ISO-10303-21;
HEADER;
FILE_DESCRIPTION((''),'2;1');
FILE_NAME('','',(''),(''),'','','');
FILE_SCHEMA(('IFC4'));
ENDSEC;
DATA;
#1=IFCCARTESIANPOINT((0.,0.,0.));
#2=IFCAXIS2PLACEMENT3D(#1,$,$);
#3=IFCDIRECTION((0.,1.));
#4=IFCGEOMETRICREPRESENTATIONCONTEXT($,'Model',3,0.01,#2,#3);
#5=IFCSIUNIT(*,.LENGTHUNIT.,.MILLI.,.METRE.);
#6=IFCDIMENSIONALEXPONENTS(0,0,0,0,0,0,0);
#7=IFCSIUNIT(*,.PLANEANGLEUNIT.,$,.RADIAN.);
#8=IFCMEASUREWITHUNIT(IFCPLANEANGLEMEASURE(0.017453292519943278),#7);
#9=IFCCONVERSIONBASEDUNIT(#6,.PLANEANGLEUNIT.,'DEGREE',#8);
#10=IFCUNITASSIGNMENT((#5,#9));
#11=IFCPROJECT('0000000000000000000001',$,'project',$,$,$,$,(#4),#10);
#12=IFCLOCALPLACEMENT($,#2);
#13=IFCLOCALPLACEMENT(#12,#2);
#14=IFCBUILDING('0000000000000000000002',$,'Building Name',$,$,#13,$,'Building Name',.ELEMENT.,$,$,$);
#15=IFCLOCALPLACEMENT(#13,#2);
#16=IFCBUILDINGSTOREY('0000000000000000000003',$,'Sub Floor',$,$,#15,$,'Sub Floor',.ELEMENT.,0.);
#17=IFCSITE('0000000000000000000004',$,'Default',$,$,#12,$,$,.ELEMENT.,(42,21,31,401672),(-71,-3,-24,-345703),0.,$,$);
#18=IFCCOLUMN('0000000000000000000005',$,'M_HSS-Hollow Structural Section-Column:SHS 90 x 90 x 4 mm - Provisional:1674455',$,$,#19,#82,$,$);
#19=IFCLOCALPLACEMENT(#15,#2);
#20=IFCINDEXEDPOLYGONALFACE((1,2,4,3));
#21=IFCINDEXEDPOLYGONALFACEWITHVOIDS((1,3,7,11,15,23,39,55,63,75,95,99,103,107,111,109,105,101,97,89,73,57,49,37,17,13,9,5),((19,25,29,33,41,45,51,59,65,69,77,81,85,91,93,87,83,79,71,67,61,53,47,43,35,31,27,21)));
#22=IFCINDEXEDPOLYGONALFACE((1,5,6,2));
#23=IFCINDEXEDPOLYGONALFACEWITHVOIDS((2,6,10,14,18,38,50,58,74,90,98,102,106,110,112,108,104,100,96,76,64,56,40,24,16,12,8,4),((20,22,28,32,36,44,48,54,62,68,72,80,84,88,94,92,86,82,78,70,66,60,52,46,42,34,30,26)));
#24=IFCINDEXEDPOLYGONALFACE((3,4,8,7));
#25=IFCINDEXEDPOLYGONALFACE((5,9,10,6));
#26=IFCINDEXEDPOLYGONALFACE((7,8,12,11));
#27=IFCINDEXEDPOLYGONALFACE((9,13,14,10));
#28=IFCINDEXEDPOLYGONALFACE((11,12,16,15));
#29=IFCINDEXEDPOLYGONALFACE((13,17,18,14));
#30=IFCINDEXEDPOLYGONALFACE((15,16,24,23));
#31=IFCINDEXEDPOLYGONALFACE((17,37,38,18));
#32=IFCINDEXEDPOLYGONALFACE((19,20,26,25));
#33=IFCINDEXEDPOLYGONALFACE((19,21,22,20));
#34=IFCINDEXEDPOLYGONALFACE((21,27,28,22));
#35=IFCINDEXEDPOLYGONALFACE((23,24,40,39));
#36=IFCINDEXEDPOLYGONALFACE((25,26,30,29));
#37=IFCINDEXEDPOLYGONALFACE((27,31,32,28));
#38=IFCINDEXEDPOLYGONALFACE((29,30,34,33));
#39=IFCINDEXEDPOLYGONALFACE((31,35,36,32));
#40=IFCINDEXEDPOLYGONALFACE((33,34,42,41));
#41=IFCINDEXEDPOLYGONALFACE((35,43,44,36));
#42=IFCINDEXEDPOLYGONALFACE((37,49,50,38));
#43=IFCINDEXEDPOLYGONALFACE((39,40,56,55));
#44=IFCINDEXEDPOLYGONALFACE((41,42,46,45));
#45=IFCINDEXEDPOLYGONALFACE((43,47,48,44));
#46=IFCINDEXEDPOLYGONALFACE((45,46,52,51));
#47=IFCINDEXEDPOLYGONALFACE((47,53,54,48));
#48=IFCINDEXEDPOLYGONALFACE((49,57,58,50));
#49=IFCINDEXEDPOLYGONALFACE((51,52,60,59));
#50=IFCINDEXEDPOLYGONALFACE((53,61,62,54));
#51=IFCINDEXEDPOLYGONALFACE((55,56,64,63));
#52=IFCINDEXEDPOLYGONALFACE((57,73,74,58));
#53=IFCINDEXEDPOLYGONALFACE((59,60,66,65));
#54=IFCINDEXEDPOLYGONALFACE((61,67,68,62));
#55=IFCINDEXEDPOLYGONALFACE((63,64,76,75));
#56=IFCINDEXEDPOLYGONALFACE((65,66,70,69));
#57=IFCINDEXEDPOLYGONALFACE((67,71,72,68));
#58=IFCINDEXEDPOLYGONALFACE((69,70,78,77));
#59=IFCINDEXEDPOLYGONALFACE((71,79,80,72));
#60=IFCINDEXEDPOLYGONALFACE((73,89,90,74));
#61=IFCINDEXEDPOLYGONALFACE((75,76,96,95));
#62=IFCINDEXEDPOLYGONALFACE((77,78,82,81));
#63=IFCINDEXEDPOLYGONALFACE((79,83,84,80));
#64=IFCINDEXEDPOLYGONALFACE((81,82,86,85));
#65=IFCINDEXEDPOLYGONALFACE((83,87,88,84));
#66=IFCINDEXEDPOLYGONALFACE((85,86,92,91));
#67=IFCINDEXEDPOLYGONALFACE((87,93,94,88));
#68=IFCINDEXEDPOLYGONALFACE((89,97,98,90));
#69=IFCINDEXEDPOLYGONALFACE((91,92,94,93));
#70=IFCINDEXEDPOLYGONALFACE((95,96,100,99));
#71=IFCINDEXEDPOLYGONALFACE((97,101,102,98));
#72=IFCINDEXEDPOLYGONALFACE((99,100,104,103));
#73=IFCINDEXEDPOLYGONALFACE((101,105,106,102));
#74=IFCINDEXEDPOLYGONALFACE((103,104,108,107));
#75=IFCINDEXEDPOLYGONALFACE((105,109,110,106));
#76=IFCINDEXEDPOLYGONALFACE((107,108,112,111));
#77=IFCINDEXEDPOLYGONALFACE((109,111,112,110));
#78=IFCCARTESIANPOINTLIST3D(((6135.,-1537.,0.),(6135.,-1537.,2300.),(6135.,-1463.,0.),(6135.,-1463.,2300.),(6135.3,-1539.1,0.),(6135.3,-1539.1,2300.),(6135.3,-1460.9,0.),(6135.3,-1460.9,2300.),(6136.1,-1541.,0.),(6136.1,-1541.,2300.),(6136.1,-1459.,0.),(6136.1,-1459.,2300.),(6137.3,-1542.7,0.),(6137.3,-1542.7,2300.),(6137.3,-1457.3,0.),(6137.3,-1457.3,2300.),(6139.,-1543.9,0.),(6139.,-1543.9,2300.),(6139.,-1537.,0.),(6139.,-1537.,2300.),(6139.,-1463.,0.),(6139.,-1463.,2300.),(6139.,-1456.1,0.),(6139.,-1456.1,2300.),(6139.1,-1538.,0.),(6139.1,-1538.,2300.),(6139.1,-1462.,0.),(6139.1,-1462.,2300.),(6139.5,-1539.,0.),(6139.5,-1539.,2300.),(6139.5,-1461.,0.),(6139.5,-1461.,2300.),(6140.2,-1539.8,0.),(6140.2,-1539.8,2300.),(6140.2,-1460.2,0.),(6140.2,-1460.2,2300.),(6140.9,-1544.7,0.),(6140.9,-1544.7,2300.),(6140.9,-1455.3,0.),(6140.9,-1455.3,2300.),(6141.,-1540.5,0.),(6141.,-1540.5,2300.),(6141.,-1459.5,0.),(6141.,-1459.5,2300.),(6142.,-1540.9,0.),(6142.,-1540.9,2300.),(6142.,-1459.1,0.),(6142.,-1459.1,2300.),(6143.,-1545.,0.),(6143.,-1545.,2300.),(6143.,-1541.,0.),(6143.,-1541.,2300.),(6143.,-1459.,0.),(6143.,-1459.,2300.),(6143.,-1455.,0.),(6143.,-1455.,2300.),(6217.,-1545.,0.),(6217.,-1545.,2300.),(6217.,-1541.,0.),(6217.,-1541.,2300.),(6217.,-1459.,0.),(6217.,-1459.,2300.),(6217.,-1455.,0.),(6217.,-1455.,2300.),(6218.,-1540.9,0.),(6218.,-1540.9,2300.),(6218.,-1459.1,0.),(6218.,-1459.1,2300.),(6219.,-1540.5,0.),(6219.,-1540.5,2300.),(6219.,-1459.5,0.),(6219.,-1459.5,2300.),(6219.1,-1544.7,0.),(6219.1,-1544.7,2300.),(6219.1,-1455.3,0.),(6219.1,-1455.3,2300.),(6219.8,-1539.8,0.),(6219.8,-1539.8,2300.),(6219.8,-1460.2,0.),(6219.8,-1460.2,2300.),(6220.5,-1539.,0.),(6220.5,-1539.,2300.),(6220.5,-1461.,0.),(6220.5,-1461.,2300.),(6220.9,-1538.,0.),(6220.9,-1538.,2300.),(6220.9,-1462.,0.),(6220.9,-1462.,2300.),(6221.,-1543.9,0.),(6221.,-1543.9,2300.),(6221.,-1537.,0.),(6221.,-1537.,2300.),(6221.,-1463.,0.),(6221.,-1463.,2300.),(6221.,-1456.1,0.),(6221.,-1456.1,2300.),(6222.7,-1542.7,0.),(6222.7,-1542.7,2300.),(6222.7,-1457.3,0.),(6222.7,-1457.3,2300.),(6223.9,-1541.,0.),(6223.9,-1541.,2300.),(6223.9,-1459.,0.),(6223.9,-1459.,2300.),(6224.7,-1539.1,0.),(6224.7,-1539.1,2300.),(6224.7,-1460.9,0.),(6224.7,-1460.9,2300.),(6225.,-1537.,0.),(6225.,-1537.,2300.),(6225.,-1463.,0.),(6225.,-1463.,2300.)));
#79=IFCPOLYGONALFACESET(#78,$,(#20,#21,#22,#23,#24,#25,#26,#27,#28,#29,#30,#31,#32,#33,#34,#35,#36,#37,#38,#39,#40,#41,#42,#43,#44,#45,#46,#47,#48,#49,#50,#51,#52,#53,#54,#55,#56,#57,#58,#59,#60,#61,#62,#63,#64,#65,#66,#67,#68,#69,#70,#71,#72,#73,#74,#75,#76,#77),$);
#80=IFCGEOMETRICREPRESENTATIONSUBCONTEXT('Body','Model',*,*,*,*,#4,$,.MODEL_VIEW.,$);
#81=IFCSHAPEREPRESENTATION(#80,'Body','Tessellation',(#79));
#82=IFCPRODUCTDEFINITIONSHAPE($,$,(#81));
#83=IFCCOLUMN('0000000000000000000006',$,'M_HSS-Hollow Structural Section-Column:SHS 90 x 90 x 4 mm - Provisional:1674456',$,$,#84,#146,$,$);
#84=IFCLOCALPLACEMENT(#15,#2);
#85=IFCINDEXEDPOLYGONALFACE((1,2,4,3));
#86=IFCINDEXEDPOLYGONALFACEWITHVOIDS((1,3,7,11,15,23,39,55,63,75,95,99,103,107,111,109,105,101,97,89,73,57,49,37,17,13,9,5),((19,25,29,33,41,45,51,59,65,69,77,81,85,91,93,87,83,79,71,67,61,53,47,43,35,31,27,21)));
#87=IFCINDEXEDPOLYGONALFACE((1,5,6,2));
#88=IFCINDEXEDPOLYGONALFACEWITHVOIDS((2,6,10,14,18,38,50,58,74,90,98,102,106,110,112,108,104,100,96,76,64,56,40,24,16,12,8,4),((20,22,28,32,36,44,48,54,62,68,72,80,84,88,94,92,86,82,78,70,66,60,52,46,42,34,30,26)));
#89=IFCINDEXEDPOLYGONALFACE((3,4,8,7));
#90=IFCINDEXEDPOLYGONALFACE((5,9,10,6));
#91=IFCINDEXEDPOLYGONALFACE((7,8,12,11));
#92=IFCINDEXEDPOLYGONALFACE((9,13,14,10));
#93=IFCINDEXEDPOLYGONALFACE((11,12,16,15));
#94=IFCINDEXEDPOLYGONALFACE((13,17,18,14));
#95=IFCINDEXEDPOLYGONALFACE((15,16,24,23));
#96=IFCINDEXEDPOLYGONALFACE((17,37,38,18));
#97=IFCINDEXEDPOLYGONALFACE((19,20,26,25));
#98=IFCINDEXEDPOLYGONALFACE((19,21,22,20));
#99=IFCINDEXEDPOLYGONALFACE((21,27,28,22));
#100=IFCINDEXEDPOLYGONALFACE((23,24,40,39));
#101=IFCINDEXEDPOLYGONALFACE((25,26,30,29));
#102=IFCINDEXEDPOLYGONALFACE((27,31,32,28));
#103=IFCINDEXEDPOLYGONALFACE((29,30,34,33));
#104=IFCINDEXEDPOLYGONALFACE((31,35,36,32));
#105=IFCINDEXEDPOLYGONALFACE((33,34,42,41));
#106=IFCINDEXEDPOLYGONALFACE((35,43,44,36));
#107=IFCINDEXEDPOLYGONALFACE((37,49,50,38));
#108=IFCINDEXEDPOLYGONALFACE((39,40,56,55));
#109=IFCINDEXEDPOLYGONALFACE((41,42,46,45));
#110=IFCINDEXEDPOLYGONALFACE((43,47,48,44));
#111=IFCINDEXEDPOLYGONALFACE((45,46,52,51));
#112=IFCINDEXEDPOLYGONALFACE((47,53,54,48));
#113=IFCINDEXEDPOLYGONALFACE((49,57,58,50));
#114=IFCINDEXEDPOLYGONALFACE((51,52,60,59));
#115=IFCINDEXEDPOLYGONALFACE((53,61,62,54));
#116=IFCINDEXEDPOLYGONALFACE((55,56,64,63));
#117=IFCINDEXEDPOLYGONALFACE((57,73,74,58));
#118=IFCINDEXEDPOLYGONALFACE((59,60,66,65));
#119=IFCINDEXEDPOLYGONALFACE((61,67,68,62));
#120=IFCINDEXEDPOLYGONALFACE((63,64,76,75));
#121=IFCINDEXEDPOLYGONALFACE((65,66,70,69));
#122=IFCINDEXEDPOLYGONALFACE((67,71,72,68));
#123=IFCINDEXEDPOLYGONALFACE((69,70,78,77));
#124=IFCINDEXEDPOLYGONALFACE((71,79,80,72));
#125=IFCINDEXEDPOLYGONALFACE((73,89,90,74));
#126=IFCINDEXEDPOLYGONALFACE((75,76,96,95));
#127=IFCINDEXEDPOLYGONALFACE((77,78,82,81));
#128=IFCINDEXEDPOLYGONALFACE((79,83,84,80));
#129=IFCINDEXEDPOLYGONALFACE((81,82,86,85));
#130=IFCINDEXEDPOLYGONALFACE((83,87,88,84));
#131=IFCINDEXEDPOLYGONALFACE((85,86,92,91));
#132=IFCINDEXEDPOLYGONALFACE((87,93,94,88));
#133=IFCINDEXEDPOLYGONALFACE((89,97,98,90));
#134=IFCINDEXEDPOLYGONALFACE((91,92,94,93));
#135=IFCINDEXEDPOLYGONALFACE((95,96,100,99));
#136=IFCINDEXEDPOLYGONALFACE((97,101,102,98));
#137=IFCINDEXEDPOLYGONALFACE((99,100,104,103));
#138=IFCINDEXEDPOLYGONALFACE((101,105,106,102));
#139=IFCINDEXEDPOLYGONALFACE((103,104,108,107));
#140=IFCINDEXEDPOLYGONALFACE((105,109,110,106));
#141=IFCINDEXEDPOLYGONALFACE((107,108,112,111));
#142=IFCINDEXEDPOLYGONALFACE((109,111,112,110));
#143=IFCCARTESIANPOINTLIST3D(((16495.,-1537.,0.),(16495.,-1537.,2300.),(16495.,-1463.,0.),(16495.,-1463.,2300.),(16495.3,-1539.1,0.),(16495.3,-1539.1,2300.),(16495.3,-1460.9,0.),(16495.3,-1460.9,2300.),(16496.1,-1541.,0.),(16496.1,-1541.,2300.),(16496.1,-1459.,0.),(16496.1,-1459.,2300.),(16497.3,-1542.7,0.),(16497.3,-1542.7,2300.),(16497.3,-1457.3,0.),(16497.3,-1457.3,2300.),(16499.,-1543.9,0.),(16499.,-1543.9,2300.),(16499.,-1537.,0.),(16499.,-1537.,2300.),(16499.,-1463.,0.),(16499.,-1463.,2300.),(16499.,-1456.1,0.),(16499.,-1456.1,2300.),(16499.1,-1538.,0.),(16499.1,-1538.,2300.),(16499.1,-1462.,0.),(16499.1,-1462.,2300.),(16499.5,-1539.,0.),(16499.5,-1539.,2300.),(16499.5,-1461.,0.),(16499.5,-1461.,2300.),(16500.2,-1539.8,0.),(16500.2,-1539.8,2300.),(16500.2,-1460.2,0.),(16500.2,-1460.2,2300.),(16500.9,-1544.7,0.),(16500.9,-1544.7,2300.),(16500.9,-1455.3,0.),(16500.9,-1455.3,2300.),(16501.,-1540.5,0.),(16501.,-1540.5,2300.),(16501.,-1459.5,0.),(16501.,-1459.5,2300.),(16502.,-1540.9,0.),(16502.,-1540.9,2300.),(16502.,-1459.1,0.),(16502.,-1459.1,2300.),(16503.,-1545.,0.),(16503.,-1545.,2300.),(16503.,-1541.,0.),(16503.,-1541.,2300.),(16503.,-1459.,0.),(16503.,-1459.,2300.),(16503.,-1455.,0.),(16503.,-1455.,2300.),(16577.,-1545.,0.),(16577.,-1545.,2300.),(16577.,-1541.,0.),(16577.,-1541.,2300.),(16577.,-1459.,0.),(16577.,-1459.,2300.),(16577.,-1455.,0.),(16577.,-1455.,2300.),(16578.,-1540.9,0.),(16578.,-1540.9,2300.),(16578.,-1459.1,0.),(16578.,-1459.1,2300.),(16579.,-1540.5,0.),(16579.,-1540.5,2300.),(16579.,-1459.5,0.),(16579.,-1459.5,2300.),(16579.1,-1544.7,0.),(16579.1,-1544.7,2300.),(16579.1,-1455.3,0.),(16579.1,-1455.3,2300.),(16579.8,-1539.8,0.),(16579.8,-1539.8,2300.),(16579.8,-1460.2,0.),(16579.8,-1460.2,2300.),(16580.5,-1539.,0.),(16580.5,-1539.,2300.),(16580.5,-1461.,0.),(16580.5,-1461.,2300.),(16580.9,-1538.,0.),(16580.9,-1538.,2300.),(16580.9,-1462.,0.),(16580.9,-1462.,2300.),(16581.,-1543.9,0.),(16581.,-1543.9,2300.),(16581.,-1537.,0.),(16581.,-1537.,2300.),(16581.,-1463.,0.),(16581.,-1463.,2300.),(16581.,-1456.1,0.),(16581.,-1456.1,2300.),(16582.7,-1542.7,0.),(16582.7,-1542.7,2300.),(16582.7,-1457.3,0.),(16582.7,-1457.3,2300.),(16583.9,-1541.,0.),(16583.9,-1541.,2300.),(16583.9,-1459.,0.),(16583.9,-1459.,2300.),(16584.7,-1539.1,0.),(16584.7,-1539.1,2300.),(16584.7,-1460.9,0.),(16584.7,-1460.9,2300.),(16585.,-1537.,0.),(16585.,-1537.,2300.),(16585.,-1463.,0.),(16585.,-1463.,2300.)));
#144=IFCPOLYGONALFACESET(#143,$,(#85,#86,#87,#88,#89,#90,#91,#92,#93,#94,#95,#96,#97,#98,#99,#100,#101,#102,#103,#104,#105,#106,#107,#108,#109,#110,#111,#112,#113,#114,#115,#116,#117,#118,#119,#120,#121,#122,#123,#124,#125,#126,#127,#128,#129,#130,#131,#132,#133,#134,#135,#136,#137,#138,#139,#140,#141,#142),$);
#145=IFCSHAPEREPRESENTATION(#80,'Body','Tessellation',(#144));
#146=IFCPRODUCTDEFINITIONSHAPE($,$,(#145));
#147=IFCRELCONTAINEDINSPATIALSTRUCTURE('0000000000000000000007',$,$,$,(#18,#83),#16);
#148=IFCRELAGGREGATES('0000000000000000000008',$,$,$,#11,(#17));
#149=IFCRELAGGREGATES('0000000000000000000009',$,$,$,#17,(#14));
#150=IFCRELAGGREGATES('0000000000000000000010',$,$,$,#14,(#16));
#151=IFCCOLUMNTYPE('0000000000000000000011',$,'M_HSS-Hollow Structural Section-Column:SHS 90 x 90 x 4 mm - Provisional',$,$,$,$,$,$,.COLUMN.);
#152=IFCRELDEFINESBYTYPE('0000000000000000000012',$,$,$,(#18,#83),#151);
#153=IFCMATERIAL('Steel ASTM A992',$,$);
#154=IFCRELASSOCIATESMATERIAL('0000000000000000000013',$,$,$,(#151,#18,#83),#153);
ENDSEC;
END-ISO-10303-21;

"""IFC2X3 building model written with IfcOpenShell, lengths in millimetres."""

from ifc_helpers import new_model, entity, si_unit, converted_unit, direction, frame, frame_2d, origin, place, context, subcontext, project, spatial, polyline, circle_curve, parameter, trimmed, segment, composite_curve, outline, extrude, source, transform, mapped, material, type_object, type_shapes, element, save


model = new_model("IFC2X3")

# Units and contexts
model_context = context("Model", 3, precision=0.01, world=origin(), true_north=direction((0.0, 1.0)))
body_context = subcontext(model_context, "Body", "Model", "MODEL_VIEW")
ifc_project = project(units=[si_unit("LENGTHUNIT", "METRE", prefix="MILLI"), converted_unit("PLANEANGLEUNIT", "DEGREE", entity("IfcPlaneAngleMeasure", 0.017453292519943278), si_unit("PLANEANGLEUNIT", "RADIAN"), dimensions=[0, 0, 0, 0, 0, 0, 0])], contexts=[model_context])

# Site, building, storey
site_placement = place(None, origin())
site = spatial("IfcSite", under=ifc_project, at=site_placement, Name="Default", CompositionType="ELEMENT", RefLatitude=(42, 21, 31, 401672), RefLongitude=(-71, -3, -24, -345703), RefElevation=0.0)
building_placement = place(site_placement, origin())
building = spatial("IfcBuilding", under=site, at=building_placement, Name="Building Name", LongName="Building Name", CompositionType="ELEMENT")
storey_placement = place(building_placement, origin())
storey = spatial("IfcBuildingStorey", under=building, at=storey_placement, Name="Sub Floor", LongName="Sub Floor", CompositionType="ELEMENT", Elevation=0.0)

# Columns
ifc_material_1 = material(Name="Steel ASTM A992")
column_type = type_object("IfcColumnType", Name="M_HSS-Hollow Structural Section-Column:SHS 90 x 90 x 4 mm - Provisional", PredefinedType="COLUMN", material=ifc_material_1)
shared_shape_1 = source(origin(), body_context, "Body", "SweptSolid", [
    extrude(outline(composite_curve([segment(polyline([(-37.0, -45.0), (37.0, -45.0)]), True, "CONTINUOUS"), segment(trimmed(circle_curve(frame_2d((37.0, -37.0), x_axis=(-1.0, 0.0)), 8.0), [parameter(90.0)], [parameter(180.0)], True, "PARAMETER"), True, "CONTINUOUS"), segment(polyline([(45.0, -37.0), (45.0, 37.0)]), True, "CONTINUOUS"), segment(trimmed(circle_curve(frame_2d((37.0, 37.0), x_axis=(-1.0, 0.0)), 8.0), [parameter(180.0)], [parameter(270.0)], True, "PARAMETER"), True, "CONTINUOUS"), segment(polyline([(37.0, 45.0), (-37.0, 45.0)]), True, "CONTINUOUS"), segment(trimmed(circle_curve(frame_2d((-37.0, 37.0), x_axis=(-1.0, 0.0)), 8.0), [parameter(270.0)], [parameter(360.0)], True, "PARAMETER"), True, "CONTINUOUS"), segment(polyline([(-45.0, 37.0), (-45.0, -37.0)]), True, "CONTINUOUS"), segment(trimmed(circle_curve(frame_2d((-37.0, -37.0), x_axis=(-1.0, 0.0)), 8.0), [parameter(360.0)], [parameter(90.0)], True, "PARAMETER"), True, "CONTINUOUS")], self_intersect=False), holes=[composite_curve([segment(trimmed(circle_curve(frame_2d((-37.0, -37.0), x_axis=(-1.0, 0.0)), 4.0), [parameter(0.0)], [parameter(90.0)], True, "PARAMETER"), False, "CONTINUOUS"), segment(polyline([(-41.0, -37.0), (-41.0, 37.0)]), True, "CONTINUOUS"), segment(trimmed(circle_curve(frame_2d((-37.0, 37.0), x_axis=(-1.0, 0.0)), 4.0), [parameter(270.0)], [parameter(0.0)], True, "PARAMETER"), False, "CONTINUOUS"), segment(polyline([(-37.0, 41.0), (37.0, 41.0)]), True, "CONTINUOUS"), segment(trimmed(circle_curve(frame_2d((37.0, 37.0), x_axis=(-1.0, 0.0)), 4.0), [parameter(180.0)], [parameter(270.0)], True, "PARAMETER"), False, "CONTINUOUS"), segment(polyline([(41.0, 37.0), (41.0, -37.0)]), True, "CONTINUOUS"), segment(trimmed(circle_curve(frame_2d((37.0, -37.0), x_axis=(-1.0, 0.0)), 4.0), [parameter(90.0)], [parameter(180.0)], True, "PARAMETER"), False, "CONTINUOUS"), segment(polyline([(37.0, -41.0), (-37.0, -41.0)]), True, "CONTINUOUS")], self_intersect=False)]), frame((0.0, 0.0, 0.0), z_axis=(0.0, 0.0, 1.0), x_axis=(-1.0, 0.0, 0.0)), (0.0, 0.0, 1.0), 2300.0),
])
type_shapes(column_type, [shared_shape_1])
for number, where, name in (
    (1, (6180.0, -1500.0, 0.0), "M_HSS-Hollow Structural Section-Column:SHS 90 x 90 x 4 mm - Provisional:1674455"),
    (2, (16540.0, -1500.0, 0.0), "M_HSS-Hollow Structural Section-Column:SHS 90 x 90 x 4 mm - Provisional:1674456"),
):
    element("IfcColumn", number, at=place(storey_placement, frame(where)), inside=storey, type_object=column_type, material=ifc_material_1, Name=name, context=body_context, shape_type="MappedRepresentation", body=[
        mapped(shared_shape_1, transform((0.0, 0.0, 0.0), scale=1.0)),
    ])

save(model, "model.ifc")
